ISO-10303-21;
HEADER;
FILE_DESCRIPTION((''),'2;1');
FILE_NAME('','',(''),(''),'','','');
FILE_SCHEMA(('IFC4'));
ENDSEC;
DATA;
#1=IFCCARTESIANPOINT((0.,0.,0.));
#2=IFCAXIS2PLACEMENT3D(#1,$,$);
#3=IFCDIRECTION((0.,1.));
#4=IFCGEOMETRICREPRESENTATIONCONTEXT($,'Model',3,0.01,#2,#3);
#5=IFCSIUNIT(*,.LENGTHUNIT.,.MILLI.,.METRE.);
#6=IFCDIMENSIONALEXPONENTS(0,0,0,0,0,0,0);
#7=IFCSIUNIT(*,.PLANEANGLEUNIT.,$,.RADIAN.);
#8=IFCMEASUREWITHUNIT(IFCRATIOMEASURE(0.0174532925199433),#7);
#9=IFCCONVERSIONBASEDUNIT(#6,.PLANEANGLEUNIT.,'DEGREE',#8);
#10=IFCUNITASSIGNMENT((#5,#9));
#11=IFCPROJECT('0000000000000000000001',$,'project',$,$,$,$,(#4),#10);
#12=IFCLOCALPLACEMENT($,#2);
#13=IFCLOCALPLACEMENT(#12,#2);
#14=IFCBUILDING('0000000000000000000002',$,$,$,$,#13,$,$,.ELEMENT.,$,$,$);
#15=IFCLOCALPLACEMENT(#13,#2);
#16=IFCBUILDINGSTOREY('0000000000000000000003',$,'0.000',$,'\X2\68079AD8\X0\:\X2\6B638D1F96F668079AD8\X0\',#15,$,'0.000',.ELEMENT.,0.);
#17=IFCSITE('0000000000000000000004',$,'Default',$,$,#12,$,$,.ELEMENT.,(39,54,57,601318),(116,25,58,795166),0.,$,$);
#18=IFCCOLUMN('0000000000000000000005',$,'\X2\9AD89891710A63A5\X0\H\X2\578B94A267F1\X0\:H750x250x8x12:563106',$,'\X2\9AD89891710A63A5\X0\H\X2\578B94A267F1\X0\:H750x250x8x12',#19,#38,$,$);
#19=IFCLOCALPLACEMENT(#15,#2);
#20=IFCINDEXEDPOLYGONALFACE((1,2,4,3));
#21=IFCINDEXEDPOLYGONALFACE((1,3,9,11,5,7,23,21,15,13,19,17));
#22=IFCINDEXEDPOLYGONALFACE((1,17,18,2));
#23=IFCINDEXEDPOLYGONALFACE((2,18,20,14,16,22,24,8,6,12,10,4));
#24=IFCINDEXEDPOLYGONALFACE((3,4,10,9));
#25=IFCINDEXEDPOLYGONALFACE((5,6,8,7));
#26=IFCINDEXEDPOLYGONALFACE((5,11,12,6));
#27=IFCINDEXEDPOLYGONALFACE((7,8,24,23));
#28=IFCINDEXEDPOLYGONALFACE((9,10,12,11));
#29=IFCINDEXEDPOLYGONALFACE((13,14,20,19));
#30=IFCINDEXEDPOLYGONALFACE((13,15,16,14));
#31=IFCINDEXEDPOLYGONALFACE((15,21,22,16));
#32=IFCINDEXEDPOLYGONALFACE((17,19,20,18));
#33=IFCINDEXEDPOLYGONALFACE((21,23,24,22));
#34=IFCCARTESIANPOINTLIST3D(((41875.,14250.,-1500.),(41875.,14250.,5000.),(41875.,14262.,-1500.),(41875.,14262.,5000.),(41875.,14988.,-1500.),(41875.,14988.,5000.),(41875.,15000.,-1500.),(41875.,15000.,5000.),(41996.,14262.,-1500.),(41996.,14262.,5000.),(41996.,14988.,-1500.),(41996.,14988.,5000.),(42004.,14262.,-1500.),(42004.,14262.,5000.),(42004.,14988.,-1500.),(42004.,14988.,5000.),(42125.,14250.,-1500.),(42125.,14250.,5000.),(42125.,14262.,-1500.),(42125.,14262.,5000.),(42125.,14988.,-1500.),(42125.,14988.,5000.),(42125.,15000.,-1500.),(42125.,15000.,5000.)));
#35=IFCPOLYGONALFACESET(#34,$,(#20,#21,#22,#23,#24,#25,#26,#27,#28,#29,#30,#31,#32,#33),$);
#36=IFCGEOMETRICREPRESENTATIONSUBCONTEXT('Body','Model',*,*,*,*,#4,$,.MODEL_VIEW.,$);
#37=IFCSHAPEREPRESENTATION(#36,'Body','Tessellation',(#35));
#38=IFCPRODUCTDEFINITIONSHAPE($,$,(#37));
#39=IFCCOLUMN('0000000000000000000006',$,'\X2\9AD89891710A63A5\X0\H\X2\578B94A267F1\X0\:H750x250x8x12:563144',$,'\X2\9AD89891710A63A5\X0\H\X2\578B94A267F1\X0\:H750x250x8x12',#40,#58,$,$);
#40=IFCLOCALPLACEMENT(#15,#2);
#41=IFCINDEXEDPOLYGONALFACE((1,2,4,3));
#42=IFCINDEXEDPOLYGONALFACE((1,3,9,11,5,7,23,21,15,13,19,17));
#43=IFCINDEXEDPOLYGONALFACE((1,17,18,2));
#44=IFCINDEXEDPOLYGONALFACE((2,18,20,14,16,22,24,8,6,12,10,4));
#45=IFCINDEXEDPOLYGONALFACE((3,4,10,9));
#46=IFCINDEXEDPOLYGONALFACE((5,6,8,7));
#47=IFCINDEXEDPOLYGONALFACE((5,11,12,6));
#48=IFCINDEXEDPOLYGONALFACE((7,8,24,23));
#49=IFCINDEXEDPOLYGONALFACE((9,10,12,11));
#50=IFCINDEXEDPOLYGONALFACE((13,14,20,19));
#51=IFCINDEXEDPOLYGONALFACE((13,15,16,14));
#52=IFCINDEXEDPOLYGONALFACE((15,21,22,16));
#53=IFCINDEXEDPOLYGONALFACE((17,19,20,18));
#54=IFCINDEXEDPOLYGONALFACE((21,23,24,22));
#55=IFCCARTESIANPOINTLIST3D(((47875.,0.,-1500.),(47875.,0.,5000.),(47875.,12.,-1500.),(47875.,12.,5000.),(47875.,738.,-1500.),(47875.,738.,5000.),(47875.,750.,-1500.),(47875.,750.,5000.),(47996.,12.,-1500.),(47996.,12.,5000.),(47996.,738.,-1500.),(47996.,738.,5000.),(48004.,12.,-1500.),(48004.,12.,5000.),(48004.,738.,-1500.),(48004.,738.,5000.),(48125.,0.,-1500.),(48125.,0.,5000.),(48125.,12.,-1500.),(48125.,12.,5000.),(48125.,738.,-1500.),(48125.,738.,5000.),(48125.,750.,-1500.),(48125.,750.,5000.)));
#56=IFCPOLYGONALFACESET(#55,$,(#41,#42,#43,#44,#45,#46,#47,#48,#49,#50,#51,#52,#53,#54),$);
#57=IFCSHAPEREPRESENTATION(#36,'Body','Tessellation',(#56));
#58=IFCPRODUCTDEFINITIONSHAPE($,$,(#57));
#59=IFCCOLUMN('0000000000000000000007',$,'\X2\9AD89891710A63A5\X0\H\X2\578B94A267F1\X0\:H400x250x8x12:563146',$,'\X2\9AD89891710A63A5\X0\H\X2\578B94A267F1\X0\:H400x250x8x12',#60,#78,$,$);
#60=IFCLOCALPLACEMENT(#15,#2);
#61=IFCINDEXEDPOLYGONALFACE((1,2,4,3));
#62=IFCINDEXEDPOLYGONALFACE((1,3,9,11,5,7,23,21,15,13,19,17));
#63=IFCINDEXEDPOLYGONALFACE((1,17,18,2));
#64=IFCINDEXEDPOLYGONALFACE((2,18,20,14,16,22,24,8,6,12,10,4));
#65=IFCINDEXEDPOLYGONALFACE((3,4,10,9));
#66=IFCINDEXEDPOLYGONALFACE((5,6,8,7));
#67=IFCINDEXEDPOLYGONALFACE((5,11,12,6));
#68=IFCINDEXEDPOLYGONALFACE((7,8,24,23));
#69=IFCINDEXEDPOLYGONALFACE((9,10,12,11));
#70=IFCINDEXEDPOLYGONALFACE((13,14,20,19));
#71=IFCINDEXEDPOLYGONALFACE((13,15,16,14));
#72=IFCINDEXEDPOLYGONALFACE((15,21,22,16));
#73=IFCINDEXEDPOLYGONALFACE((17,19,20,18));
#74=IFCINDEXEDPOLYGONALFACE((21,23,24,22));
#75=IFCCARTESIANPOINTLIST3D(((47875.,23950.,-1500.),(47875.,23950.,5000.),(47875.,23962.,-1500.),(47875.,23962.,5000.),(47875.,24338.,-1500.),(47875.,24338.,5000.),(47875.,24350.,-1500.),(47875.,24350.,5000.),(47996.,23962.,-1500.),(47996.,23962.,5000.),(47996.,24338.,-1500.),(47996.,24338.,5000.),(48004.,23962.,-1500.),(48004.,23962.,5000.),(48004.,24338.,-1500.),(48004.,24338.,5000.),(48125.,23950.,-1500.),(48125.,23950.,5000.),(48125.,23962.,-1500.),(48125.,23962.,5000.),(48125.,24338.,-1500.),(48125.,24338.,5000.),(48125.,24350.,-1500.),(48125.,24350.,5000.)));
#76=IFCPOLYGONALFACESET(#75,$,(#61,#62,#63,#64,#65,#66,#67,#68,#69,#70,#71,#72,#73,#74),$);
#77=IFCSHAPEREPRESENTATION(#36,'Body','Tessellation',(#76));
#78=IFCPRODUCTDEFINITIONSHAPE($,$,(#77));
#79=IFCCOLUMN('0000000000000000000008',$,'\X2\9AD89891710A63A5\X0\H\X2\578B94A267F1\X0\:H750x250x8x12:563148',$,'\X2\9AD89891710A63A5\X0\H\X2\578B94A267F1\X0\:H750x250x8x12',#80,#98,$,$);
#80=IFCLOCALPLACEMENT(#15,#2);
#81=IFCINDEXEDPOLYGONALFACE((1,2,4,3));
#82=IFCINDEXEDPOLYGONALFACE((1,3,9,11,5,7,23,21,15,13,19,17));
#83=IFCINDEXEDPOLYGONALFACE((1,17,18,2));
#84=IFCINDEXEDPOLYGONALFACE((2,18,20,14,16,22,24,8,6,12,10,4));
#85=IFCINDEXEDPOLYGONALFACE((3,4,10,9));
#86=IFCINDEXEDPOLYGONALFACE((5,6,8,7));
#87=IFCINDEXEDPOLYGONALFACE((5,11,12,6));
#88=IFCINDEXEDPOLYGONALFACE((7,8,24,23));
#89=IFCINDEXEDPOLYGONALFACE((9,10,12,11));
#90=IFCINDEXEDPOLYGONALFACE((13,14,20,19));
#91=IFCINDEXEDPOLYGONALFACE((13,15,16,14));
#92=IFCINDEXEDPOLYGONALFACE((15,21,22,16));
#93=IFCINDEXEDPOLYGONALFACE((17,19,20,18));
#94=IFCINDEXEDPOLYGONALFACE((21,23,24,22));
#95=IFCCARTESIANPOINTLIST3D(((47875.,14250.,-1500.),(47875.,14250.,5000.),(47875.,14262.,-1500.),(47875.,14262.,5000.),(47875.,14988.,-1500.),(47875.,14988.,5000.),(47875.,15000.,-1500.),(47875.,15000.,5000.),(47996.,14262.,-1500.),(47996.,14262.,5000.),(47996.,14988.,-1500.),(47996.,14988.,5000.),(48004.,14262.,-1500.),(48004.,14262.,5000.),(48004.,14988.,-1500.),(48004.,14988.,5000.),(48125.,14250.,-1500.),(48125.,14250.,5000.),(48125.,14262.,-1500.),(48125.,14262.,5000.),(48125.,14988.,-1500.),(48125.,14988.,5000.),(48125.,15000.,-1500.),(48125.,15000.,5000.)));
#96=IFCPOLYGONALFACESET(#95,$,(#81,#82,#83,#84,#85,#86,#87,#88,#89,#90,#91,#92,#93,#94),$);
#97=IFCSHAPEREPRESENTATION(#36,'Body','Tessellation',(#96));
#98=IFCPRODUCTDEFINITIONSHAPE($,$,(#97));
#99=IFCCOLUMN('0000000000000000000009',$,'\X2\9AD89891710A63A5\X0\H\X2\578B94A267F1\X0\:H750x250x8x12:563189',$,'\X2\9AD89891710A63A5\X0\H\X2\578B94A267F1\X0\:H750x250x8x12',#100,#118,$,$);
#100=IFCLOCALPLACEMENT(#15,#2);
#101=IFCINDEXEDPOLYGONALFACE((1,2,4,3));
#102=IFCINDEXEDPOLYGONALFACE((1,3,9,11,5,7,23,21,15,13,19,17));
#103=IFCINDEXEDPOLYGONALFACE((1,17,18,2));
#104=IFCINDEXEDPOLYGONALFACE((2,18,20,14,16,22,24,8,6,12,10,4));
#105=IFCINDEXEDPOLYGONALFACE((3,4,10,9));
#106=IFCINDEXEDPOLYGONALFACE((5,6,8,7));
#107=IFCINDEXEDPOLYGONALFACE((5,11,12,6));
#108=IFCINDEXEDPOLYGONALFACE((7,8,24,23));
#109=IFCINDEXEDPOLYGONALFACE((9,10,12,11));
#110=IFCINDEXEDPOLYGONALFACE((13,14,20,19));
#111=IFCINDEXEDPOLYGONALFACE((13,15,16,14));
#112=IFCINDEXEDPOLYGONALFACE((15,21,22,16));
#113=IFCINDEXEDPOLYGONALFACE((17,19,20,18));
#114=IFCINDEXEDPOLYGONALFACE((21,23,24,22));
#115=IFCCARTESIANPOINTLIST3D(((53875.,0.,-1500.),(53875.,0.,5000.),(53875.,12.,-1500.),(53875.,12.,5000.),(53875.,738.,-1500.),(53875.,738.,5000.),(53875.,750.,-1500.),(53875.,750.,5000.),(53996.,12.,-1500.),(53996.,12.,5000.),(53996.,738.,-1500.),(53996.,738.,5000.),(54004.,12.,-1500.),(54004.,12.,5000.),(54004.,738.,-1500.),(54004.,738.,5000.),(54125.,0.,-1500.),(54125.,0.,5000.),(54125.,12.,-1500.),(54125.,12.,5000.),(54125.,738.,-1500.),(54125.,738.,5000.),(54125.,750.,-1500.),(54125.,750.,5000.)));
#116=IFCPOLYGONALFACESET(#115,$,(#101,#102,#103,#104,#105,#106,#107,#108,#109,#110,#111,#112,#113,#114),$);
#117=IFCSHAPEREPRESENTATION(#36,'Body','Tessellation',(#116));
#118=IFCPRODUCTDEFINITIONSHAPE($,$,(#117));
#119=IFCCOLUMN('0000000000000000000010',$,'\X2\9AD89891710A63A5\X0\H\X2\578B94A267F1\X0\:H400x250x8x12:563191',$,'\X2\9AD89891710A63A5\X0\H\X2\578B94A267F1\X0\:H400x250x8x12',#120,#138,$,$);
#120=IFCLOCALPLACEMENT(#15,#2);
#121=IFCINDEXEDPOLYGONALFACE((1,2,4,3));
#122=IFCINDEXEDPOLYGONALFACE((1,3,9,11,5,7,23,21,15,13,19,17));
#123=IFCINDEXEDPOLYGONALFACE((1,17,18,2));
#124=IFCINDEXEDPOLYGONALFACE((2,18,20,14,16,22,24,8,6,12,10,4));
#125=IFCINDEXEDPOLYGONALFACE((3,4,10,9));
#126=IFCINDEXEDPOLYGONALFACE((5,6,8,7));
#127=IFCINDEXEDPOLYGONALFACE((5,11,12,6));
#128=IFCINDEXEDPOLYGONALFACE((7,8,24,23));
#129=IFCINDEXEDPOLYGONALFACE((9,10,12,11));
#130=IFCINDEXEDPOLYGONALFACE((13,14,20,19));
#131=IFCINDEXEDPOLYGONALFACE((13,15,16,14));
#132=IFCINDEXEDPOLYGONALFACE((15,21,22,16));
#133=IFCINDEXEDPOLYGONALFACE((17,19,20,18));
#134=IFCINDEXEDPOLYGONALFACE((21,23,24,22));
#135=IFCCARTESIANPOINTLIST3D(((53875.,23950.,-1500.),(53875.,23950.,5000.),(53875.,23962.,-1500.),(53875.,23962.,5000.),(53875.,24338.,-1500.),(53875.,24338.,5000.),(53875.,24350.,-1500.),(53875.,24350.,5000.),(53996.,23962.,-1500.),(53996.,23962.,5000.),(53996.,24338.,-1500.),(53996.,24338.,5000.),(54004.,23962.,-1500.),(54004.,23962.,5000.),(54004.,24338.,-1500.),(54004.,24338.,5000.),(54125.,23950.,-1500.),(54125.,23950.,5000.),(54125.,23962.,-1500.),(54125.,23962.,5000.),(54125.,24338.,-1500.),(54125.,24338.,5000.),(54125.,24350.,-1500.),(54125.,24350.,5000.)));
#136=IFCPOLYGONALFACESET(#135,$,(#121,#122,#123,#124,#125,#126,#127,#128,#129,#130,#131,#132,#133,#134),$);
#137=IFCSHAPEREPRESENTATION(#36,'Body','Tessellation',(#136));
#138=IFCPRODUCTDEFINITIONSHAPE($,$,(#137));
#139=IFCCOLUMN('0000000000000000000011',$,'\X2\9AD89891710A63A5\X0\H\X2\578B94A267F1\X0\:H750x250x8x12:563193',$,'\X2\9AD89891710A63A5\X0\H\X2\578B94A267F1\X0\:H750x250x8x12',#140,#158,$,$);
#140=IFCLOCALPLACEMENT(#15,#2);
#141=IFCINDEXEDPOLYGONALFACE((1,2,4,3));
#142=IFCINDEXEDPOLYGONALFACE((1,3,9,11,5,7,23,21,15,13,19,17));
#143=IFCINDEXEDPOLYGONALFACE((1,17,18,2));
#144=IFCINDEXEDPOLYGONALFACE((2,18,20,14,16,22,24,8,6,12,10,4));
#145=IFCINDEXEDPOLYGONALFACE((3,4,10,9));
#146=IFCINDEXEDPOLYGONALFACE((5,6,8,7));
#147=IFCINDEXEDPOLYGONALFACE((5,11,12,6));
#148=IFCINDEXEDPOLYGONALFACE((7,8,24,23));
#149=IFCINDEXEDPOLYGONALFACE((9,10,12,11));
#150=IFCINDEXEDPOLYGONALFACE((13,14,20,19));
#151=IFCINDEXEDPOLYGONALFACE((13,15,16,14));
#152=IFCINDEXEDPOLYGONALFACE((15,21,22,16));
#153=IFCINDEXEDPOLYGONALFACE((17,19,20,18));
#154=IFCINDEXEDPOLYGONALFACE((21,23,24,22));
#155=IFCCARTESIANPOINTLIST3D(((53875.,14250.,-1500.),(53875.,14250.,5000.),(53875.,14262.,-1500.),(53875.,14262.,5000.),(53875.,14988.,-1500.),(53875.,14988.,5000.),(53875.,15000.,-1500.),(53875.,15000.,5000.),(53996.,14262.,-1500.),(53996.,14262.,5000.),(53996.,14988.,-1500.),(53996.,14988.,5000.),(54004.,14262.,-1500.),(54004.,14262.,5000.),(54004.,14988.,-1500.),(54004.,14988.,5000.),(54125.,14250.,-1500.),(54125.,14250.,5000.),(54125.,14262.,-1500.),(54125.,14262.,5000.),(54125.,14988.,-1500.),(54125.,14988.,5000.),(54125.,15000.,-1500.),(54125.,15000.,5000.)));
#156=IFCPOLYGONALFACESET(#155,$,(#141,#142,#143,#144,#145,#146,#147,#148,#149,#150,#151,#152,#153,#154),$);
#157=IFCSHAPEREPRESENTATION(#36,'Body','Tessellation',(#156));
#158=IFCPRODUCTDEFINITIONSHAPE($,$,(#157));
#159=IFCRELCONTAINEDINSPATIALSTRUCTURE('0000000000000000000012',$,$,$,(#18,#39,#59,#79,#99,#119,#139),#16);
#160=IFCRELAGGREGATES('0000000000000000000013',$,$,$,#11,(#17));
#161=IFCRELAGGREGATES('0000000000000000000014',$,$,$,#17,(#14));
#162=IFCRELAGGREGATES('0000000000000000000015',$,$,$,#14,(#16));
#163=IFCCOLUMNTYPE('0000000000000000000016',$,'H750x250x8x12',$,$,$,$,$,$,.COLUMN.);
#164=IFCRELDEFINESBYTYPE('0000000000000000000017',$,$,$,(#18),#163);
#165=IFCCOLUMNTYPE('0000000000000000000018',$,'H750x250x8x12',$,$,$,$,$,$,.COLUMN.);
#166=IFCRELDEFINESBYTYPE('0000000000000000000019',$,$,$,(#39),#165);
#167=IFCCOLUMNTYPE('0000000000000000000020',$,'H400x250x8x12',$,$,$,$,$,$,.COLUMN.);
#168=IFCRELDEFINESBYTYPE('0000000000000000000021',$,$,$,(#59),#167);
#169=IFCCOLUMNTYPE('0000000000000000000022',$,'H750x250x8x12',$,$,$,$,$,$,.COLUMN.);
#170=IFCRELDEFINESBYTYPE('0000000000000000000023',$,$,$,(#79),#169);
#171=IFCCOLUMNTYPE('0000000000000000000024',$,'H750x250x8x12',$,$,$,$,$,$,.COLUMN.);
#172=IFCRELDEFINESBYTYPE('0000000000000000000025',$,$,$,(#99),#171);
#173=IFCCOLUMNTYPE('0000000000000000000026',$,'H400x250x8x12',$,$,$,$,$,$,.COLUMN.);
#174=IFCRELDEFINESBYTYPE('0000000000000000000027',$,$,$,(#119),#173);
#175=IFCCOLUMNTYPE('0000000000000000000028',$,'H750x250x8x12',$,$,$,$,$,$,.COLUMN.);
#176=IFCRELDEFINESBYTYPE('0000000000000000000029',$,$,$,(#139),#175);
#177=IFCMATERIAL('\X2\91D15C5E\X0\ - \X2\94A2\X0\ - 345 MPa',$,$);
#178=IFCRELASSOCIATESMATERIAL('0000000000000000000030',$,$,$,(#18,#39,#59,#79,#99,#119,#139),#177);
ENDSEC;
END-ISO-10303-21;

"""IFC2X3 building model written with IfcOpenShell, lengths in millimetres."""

from ifc_helpers import new_model, entity, si_unit, converted_unit, direction, frame, origin, place, context, subcontext, project, spatial, polyline, outline, extrude, source, transform, mapped, material, type_object, type_shapes, element, save


model = new_model("IFC2X3")

# Units and contexts
model_context = context("Model", 3, precision=0.01, world=origin(), true_north=direction((0.0, 1.0)))
body_context = subcontext(model_context, "Body", "Model", "MODEL_VIEW")
ifc_project = project(units=[si_unit("LENGTHUNIT", "METRE", prefix="MILLI"), converted_unit("PLANEANGLEUNIT", "DEGREE", entity("IfcRatioMeasure", 0.0174532925199433), si_unit("PLANEANGLEUNIT", "RADIAN"), dimensions=[0, 0, 0, 0, 0, 0, 0])], contexts=[model_context])

# Site, building, storey
site_placement = place(None, origin())
site = spatial("IfcSite", under=ifc_project, at=site_placement, Name="Default", CompositionType="ELEMENT", RefLatitude=(39, 54, 57, 601318), RefLongitude=(116, 25, 58, 795166), RefElevation=0.0)
building_placement = place(site_placement, origin())
building = spatial("IfcBuilding", under=site, at=building_placement, CompositionType="ELEMENT")
storey_placement = place(building_placement, origin())
storey = spatial("IfcBuildingStorey", under=building, at=storey_placement, Name="0.000", ObjectType="标高:正负零标高", LongName="0.000", CompositionType="ELEMENT", Elevation=0.0)

# Columns
ifc_material_1 = material(Name="金属 - 钢 - 345 MPa")
column_type_1 = type_object("IfcColumnType", Name="H750x250x8x12", PredefinedType="COLUMN")
shared_shape_1 = source(origin(), body_context, "Body", "SweptSolid", [
    extrude(outline(polyline([(363.0, -125.0), (375.0, -125.0), (375.0, 125.0), (363.0, 125.0), (363.0, 4.0), (-363.0, 4.0), (-363.0, 125.0), (-375.0, 125.0), (-375.0, -125.0), (-363.0, -125.0), (-363.0, -4.0), (363.0, -4.0), (363.0, -125.0)])), frame((42000.0, 14625.0, -1500.0), z_axis=(0.0, 0.0, 1.0), x_axis=(0.0, -1.0, 0.0)), (0.0, 0.0, 1.0), 6500.0),
])
type_shapes(column_type_1, [shared_shape_1])
column_1_placement = place(storey_placement, origin())
element("IfcColumn", 1, at=column_1_placement, inside=storey, type_object=column_type_1, material=ifc_material_1, Name="高频焊接H型钢柱:H750x250x8x12:563106", ObjectType="高频焊接H型钢柱:H750x250x8x12", context=body_context, shape_type="MappedRepresentation", body=[
    mapped(shared_shape_1, transform((0.0, 0.0, 0.0), scale=1.0)),
])
column_type_2 = type_object("IfcColumnType", Name="H750x250x8x12", PredefinedType="COLUMN")
shared_shape_2 = source(origin(), body_context, "Body", "SweptSolid", [
    extrude(outline(polyline([(363.0, -125.0), (375.0, -125.0), (375.0, 125.0), (363.0, 125.0), (363.0, 4.0), (-363.0, 4.0), (-363.0, 125.0), (-375.0, 125.0), (-375.0, -125.0), (-363.0, -125.0), (-363.0, -4.0), (363.0, -4.0), (363.0, -125.0)])), frame((48000.0, 375.0, -1500.0), z_axis=(0.0, 0.0, 1.0), x_axis=(0.0, -1.0, 0.0)), (0.0, 0.0, 1.0), 6500.0),
])
type_shapes(column_type_2, [shared_shape_2])
column_2_placement = place(storey_placement, origin())
element("IfcColumn", 2, at=column_2_placement, inside=storey, type_object=column_type_2, material=ifc_material_1, Name="高频焊接H型钢柱:H750x250x8x12:563144", ObjectType="高频焊接H型钢柱:H750x250x8x12", context=body_context, shape_type="MappedRepresentation", body=[
    mapped(shared_shape_2, transform((0.0, 0.0, 0.0), scale=1.0)),
])
column_type_3 = type_object("IfcColumnType", Name="H400x250x8x12", PredefinedType="COLUMN")
shared_shape_3 = source(origin(), body_context, "Body", "SweptSolid", [
    extrude(outline(polyline([(188.0, -125.0), (200.0, -125.0), (200.0, 125.0), (188.0, 125.0), (188.0, 4.0), (-188.0, 4.0), (-188.0, 125.0), (-200.0, 125.0), (-200.0, -125.0), (-188.0, -125.0), (-188.0, -4.0), (188.0, -4.0), (188.0, -125.0)])), frame((48000.0, 24150.0, -1500.0), z_axis=(0.0, 0.0, 1.0), x_axis=(0.0, -1.0, 0.0)), (0.0, 0.0, 1.0), 6500.0),
])
type_shapes(column_type_3, [shared_shape_3])
column_3_placement = place(storey_placement, origin())
element("IfcColumn", 3, at=column_3_placement, inside=storey, type_object=column_type_3, material=ifc_material_1, Name="高频焊接H型钢柱:H400x250x8x12:563146", ObjectType="高频焊接H型钢柱:H400x250x8x12", context=body_context, shape_type="MappedRepresentation", body=[
    mapped(shared_shape_3, transform((0.0, 0.0, 0.0), scale=1.0)),
])
column_type_4 = type_object("IfcColumnType", Name="H750x250x8x12", PredefinedType="COLUMN")
shared_shape_4 = source(origin(), body_context, "Body", "SweptSolid", [
    extrude(outline(polyline([(363.0, -125.0), (375.0, -125.0), (375.0, 125.0), (363.0, 125.0), (363.0, 4.0), (-363.0, 4.0), (-363.0, 125.0), (-375.0, 125.0), (-375.0, -125.0), (-363.0, -125.0), (-363.0, -4.0), (363.0, -4.0), (363.0, -125.0)])), frame((48000.0, 14625.0, -1500.0), z_axis=(0.0, 0.0, 1.0), x_axis=(0.0, -1.0, 0.0)), (0.0, 0.0, 1.0), 6500.0),
])
type_shapes(column_type_4, [shared_shape_4])
column_4_placement = place(storey_placement, origin())
element("IfcColumn", 4, at=column_4_placement, inside=storey, type_object=column_type_4, material=ifc_material_1, Name="高频焊接H型钢柱:H750x250x8x12:563148", ObjectType="高频焊接H型钢柱:H750x250x8x12", context=body_context, shape_type="MappedRepresentation", body=[
    mapped(shared_shape_4, transform((0.0, 0.0, 0.0), scale=1.0)),
])
column_type_5 = type_object("IfcColumnType", Name="H750x250x8x12", PredefinedType="COLUMN")
shared_shape_5 = source(origin(), body_context, "Body", "SweptSolid", [
    extrude(outline(polyline([(363.0, -125.0), (375.0, -125.0), (375.0, 125.0), (363.0, 125.0), (363.0, 4.0), (-363.0, 4.0), (-363.0, 125.0), (-375.0, 125.0), (-375.0, -125.0), (-363.0, -125.0), (-363.0, -4.0), (363.0, -4.0), (363.0, -125.0)])), frame((54000.0, 375.0, -1500.0), z_axis=(0.0, 0.0, 1.0), x_axis=(0.0, -1.0, 0.0)), (0.0, 0.0, 1.0), 6500.0),
])
type_shapes(column_type_5, [shared_shape_5])
column_5_placement = place(storey_placement, origin())
element("IfcColumn", 5, at=column_5_placement, inside=storey, type_object=column_type_5, material=ifc_material_1, Name="高频焊接H型钢柱:H750x250x8x12:563189", ObjectType="高频焊接H型钢柱:H750x250x8x12", context=body_context, shape_type="MappedRepresentation", body=[
    mapped(shared_shape_5, transform((0.0, 0.0, 0.0), scale=1.0)),
])
column_type_6 = type_object("IfcColumnType", Name="H400x250x8x12", PredefinedType="COLUMN")
shared_shape_6 = source(origin(), body_context, "Body", "SweptSolid", [
    extrude(outline(polyline([(188.0, -125.0), (200.0, -125.0), (200.0, 125.0), (188.0, 125.0), (188.0, 4.0), (-188.0, 4.0), (-188.0, 125.0), (-200.0, 125.0), (-200.0, -125.0), (-188.0, -125.0), (-188.0, -4.0), (188.0, -4.0), (188.0, -125.0)])), frame((54000.0, 24150.0, -1500.0), z_axis=(0.0, 0.0, 1.0), x_axis=(0.0, -1.0, 0.0)), (0.0, 0.0, 1.0), 6500.0),
])
type_shapes(column_type_6, [shared_shape_6])
column_6_placement = place(storey_placement, origin())
element("IfcColumn", 6, at=column_6_placement, inside=storey, type_object=column_type_6, material=ifc_material_1, Name="高频焊接H型钢柱:H400x250x8x12:563191", ObjectType="高频焊接H型钢柱:H400x250x8x12", context=body_context, shape_type="MappedRepresentation", body=[
    mapped(shared_shape_6, transform((0.0, 0.0, 0.0), scale=1.0)),
])
column_type_7 = type_object("IfcColumnType", Name="H750x250x8x12", PredefinedType="COLUMN")
shared_shape_7 = source(origin(), body_context, "Body", "SweptSolid", [
    extrude(outline(polyline([(363.0, -125.0), (375.0, -125.0), (375.0, 125.0), (363.0, 125.0), (363.0, 4.0), (-363.0, 4.0), (-363.0, 125.0), (-375.0, 125.0), (-375.0, -125.0), (-363.0, -125.0), (-363.0, -4.0), (363.0, -4.0), (363.0, -125.0)])), frame((54000.0, 14625.0, -1500.0), z_axis=(0.0, 0.0, 1.0), x_axis=(0.0, -1.0, 0.0)), (0.0, 0.0, 1.0), 6500.0),
])
type_shapes(column_type_7, [shared_shape_7])
column_7_placement = place(storey_placement, origin())
element("IfcColumn", 7, at=column_7_placement, inside=storey, type_object=column_type_7, material=ifc_material_1, Name="高频焊接H型钢柱:H750x250x8x12:563193", ObjectType="高频焊接H型钢柱:H750x250x8x12", context=body_context, shape_type="MappedRepresentation", body=[
    mapped(shared_shape_7, transform((0.0, 0.0, 0.0), scale=1.0)),
])

save(model, "model.ifc")
